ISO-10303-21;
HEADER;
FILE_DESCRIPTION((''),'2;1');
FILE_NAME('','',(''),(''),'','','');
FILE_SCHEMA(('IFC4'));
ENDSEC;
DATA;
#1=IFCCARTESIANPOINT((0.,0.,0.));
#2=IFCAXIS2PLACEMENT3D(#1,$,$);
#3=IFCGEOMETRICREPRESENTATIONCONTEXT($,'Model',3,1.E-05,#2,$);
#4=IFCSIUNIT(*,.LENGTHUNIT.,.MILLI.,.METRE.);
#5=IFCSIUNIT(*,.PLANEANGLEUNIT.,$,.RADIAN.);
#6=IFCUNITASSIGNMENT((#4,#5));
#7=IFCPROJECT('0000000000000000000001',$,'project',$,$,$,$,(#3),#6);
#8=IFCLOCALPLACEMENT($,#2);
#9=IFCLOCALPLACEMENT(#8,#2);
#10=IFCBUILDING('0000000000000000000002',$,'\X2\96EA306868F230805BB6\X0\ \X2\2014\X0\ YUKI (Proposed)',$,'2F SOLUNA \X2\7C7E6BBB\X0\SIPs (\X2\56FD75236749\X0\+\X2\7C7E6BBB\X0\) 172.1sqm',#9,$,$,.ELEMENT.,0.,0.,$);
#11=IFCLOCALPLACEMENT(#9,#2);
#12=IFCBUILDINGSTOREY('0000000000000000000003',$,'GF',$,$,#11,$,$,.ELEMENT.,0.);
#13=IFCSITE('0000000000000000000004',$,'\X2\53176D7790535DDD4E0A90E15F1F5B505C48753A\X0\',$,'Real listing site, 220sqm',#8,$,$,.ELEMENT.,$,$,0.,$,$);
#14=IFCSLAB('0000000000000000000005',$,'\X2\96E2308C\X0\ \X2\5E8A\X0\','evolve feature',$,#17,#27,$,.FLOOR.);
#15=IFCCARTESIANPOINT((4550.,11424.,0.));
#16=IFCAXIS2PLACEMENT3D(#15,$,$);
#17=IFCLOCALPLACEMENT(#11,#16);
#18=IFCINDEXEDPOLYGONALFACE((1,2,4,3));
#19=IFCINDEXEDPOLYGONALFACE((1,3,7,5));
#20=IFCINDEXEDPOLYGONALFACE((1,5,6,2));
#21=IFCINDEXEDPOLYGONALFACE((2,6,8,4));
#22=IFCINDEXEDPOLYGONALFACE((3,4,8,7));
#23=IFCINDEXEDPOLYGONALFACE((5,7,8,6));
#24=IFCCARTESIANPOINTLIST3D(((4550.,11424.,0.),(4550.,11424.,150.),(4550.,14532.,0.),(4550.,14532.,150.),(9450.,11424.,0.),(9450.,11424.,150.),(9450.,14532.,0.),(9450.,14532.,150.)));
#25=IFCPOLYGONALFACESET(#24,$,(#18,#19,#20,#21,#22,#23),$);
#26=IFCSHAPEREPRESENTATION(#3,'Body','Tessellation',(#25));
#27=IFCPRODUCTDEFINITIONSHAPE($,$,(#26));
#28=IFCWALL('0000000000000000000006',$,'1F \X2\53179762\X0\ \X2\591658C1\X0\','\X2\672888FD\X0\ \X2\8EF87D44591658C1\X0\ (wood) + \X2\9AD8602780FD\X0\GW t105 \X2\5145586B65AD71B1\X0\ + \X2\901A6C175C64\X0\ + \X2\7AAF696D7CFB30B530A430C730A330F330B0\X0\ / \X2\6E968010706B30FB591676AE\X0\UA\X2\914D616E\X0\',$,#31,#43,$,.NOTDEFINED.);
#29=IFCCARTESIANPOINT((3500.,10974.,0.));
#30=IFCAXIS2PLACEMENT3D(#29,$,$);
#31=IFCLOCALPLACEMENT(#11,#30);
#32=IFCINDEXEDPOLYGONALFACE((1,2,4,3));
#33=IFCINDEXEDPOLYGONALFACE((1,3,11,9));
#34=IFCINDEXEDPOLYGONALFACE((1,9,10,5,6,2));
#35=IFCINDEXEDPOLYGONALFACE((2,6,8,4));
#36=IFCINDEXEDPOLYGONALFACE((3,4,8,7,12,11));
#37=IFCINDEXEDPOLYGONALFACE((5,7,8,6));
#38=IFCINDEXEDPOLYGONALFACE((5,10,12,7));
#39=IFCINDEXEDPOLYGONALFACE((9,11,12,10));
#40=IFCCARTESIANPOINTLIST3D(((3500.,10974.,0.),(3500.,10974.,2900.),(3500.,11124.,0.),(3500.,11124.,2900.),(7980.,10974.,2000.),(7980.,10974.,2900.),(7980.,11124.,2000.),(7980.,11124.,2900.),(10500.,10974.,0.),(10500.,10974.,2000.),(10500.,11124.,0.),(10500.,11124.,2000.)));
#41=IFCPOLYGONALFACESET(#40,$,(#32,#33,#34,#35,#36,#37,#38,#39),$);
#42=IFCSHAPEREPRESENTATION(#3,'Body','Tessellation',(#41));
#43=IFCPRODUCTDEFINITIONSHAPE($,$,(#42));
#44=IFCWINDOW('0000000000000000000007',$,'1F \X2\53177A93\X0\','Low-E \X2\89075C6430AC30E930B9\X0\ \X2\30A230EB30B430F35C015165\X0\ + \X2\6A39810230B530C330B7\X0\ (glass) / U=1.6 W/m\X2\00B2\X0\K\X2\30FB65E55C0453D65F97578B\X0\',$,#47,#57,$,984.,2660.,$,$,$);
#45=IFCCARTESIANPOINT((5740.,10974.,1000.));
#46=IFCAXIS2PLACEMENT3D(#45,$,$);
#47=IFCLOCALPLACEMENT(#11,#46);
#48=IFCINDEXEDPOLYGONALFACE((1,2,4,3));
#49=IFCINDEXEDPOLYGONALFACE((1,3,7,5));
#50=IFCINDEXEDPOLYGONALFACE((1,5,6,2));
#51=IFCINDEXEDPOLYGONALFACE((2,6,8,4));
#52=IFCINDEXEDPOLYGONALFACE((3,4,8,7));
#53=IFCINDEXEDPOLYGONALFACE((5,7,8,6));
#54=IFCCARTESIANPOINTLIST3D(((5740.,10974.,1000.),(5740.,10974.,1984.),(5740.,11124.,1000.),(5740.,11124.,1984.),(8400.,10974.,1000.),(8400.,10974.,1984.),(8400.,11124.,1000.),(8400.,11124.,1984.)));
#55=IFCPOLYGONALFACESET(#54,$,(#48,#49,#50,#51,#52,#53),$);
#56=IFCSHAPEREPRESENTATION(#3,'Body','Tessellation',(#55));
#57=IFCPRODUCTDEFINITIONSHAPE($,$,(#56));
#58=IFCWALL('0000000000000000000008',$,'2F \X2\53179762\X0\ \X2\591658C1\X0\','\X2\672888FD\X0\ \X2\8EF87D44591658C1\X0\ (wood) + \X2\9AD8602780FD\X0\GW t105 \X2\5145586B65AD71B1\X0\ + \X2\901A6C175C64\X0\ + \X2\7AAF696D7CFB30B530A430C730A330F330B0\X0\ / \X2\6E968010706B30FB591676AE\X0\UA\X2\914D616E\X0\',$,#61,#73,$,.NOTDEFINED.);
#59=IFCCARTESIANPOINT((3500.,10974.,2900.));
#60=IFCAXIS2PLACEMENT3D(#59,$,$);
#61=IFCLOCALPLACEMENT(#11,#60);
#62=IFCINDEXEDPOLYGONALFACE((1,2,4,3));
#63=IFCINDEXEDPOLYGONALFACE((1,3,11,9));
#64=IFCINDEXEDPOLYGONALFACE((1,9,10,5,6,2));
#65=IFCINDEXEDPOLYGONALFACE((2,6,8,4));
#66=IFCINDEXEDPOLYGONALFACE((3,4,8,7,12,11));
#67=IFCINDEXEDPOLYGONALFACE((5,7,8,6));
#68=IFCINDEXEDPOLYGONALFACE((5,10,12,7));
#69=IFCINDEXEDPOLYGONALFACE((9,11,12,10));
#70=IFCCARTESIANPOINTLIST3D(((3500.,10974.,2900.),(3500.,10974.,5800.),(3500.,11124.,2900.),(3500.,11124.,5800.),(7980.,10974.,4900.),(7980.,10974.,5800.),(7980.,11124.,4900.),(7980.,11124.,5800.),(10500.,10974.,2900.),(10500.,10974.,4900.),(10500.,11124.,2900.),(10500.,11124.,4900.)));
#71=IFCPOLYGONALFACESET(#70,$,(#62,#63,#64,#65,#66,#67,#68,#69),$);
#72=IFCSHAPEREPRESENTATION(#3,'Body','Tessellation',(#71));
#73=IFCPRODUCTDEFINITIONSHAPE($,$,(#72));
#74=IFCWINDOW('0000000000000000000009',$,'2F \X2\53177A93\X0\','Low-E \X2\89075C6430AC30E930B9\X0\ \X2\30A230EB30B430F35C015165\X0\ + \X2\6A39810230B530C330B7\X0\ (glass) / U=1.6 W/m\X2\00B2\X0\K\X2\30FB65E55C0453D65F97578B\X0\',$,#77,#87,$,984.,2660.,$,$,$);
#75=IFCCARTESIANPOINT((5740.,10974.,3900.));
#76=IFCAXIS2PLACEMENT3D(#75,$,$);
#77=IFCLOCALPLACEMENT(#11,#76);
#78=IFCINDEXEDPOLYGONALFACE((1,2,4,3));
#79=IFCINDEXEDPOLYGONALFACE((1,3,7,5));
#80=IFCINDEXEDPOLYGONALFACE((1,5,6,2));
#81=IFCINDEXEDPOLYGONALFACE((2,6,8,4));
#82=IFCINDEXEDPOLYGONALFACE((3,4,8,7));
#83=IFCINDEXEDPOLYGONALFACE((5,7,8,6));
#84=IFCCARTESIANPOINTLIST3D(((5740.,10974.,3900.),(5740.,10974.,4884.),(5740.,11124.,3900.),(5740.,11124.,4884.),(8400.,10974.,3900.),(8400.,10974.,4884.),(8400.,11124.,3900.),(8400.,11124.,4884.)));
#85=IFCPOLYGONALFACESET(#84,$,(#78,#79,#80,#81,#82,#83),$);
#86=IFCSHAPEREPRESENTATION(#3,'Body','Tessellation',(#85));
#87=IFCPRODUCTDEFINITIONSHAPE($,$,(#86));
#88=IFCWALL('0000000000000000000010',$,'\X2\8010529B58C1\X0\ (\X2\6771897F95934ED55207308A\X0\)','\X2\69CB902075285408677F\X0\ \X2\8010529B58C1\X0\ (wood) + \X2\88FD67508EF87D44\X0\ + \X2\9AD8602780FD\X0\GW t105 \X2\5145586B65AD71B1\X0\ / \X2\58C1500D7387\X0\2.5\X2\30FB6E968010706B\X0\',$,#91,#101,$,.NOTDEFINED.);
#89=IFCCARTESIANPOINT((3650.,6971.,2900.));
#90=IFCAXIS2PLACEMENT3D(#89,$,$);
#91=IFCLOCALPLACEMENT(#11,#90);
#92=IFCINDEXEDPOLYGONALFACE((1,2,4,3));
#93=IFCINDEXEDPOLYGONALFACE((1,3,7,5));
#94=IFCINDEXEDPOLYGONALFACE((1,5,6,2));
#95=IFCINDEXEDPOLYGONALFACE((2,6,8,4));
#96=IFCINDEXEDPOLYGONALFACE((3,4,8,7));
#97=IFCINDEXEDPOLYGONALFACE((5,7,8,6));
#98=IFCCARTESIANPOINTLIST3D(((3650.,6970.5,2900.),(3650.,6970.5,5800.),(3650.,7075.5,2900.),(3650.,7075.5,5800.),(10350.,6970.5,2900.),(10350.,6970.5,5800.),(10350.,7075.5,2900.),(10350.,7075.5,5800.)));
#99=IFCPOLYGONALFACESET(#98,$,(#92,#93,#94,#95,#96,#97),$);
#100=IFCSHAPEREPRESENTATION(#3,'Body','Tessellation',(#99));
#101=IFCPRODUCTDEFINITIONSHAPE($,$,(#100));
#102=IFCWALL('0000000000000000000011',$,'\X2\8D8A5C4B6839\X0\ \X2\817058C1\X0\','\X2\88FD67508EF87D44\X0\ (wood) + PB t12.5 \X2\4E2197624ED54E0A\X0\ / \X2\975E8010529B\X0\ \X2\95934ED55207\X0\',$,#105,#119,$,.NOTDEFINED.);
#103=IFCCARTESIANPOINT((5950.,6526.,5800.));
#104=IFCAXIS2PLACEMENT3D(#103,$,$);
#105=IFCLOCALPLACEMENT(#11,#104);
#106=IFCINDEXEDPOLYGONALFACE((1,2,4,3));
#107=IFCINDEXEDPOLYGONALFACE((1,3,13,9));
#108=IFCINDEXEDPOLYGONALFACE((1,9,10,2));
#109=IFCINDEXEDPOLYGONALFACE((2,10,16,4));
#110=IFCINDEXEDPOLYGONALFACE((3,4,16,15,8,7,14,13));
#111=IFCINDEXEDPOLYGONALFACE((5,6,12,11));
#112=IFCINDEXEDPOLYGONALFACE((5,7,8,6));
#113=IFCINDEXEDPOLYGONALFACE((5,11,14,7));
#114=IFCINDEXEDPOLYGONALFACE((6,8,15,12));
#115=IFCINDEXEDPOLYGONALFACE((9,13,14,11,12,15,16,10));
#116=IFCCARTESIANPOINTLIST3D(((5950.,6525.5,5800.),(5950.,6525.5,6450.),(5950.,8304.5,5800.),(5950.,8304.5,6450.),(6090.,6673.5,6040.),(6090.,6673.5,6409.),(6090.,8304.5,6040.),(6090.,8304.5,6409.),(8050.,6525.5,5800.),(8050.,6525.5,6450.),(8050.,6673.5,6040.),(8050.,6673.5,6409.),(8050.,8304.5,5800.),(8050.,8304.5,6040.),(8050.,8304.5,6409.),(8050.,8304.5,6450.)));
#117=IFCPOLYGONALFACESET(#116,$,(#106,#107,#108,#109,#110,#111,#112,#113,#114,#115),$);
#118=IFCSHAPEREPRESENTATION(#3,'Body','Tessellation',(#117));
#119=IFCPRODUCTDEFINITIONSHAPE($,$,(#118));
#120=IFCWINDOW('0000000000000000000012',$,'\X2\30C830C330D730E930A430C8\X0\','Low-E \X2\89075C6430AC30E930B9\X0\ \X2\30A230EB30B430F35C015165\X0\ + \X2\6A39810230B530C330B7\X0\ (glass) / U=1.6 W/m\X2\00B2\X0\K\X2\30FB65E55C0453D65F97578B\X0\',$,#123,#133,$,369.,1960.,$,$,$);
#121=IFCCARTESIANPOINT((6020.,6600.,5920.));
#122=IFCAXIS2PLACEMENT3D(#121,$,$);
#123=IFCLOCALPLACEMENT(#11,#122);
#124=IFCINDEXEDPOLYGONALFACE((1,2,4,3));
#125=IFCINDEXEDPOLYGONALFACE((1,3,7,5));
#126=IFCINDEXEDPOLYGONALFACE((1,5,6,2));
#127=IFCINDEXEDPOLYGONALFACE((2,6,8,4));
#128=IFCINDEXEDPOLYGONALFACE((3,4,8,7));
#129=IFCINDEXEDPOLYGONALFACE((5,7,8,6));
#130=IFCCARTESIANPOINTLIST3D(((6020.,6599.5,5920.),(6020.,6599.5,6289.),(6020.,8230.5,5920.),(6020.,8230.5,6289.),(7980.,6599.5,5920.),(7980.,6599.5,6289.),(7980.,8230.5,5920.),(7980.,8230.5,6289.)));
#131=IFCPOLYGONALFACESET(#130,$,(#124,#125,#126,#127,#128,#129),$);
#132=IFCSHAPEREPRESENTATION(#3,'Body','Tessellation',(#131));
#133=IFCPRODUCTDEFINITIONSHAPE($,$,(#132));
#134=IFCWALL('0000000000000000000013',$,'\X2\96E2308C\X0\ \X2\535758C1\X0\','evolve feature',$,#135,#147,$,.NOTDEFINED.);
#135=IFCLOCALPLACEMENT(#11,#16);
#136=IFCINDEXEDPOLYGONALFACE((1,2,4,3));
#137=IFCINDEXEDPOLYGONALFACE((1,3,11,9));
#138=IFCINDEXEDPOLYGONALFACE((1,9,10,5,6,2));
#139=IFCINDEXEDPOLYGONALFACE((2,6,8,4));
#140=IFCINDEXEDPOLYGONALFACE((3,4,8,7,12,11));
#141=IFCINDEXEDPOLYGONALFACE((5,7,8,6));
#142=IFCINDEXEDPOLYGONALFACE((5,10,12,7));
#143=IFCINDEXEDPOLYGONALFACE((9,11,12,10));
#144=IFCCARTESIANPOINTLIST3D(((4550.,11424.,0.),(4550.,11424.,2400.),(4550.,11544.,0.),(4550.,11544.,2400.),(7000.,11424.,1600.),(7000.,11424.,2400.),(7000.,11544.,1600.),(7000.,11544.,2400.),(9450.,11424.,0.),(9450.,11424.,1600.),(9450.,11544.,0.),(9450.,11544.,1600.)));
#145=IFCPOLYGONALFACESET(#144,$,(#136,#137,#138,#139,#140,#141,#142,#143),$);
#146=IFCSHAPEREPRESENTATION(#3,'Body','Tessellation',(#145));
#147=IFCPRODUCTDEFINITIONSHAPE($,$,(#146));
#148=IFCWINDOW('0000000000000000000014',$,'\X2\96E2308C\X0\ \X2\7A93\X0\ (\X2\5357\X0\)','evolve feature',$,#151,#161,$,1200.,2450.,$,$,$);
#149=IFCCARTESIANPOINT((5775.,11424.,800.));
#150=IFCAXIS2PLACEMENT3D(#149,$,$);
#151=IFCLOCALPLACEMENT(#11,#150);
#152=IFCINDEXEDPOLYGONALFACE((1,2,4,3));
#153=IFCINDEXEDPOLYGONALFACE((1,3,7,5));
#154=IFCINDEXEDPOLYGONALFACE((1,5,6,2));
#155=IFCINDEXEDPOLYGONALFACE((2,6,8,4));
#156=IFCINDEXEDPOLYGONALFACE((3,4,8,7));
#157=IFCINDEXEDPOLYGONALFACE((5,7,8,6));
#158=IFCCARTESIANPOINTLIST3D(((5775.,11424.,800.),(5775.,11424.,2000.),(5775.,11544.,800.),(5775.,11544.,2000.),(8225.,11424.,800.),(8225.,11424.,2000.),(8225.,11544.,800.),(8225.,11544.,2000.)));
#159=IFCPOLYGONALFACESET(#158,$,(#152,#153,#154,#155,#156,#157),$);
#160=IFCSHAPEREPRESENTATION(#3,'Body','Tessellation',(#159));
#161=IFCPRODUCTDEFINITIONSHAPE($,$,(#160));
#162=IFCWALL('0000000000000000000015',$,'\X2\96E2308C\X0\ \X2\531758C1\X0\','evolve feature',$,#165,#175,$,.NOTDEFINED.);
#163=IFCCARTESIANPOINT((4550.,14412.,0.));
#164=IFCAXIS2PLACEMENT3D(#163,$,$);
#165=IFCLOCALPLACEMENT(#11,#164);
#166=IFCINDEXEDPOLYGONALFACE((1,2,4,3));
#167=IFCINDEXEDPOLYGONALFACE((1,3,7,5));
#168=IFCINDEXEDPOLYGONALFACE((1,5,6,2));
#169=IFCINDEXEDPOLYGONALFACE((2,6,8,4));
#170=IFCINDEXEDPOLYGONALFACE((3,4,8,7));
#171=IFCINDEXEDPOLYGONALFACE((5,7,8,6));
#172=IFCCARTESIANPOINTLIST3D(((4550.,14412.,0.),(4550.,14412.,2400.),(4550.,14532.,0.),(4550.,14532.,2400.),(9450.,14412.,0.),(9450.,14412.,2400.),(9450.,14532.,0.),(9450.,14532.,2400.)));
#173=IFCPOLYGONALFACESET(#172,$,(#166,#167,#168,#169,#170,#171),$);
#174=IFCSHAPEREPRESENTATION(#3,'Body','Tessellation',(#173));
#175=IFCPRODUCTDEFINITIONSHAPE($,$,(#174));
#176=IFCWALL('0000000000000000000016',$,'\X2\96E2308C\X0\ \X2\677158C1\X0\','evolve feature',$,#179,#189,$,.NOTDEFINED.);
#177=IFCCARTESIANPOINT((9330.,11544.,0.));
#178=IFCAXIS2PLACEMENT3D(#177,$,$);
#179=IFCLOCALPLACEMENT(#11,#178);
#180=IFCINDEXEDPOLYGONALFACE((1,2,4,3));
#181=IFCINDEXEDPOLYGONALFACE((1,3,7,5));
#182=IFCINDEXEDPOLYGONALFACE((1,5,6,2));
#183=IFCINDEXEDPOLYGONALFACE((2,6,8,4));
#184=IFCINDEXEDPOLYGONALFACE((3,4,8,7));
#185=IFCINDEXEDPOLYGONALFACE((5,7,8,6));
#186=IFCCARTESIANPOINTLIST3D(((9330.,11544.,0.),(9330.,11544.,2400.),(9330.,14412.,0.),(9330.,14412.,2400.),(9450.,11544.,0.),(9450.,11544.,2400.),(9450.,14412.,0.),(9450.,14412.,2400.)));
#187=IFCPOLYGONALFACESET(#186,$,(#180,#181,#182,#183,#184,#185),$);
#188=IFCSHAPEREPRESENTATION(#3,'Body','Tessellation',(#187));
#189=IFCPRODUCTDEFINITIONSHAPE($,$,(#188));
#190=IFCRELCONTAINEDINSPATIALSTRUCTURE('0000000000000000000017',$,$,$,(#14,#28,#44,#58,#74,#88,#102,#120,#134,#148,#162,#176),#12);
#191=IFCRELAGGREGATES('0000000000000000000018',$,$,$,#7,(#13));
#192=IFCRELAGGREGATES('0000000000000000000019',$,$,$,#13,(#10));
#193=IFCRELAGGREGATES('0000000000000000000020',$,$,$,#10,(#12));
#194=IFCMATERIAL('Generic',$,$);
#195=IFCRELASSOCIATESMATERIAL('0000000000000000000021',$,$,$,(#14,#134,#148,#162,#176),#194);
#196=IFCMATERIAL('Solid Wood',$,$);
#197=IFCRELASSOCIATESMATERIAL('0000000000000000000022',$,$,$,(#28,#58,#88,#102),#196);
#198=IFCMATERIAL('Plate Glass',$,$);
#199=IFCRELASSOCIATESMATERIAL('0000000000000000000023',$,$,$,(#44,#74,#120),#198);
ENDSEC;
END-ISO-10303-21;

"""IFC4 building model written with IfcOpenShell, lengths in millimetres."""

from ifc_helpers import new_model, si_unit, frame, frame_2d, origin, place, context, project, spatial, rectangle, extrude, material, element, fill, save


model = new_model("IFC4")

# Units and contexts
model_context = context("Model", 3, precision=1e-05, world=origin())
ifc_project = project(units=[si_unit("LENGTHUNIT", "METRE", prefix="MILLI"), si_unit("PLANEANGLEUNIT", "RADIAN")], contexts=[model_context])

# Site, building, storey
site_placement = place(None, origin())
site = spatial("IfcSite", under=ifc_project, at=site_placement, Name="北海道川上郡弟子屈町", ObjectType="Real listing site, 220sqm", CompositionType="ELEMENT", RefElevation=0.0)
building_placement = place(site_placement, origin())
building = spatial("IfcBuilding", under=site, at=building_placement, Name="雪と棲む家 — YUKI (Proposed)", ObjectType="2F SOLUNA 籾殻SIPs (国産杉+籾殻) 172.1sqm", CompositionType="ELEMENT", ElevationOfRefHeight=0.0, ElevationOfTerrain=0.0)
storey_placement = place(building_placement, origin())
storey = spatial("IfcBuildingStorey", under=building, at=storey_placement, Name="GF", CompositionType="ELEMENT", Elevation=0.0)

# Slab
ifc_material_1 = material(Name="Generic")
slab_placement = place(storey_placement, frame((4550.0, 11424.0, 0.0)))
element("IfcSlab", 1, at=slab_placement, inside=storey, material=ifc_material_1, Name="離れ 床", Description="evolve feature", PredefinedType="FLOOR", context=model_context, shape_type="SweptSolid", body=[
    extrude(rectangle(XDim=4900.0, YDim=3108.0, at=frame_2d((2450.0, 1554.0))), frame((4550.0, 11424.0, 0.0)), (0.0, 0.0, 1.0), 150.0),
])

# Wall, opening, window
ifc_material_2 = material(Name="Solid Wood")
wall_1_placement = place(storey_placement, frame((3500.0, 10974.0, 0.0)))
wall_1 = element("IfcWall", 2, at=wall_1_placement, inside=storey, material=ifc_material_2, Name="1F 北面 外壁", Description="木製 軸組外壁 (wood) + 高性能GW t105 充填断熱 + 通気層 + 窯業系サイディング / 準耐火・外皮UA配慮", PredefinedType="NOTDEFINED", context=model_context, shape_type="SweptSolid", body=[
    extrude(rectangle(XDim=7000.0, YDim=150.0, at=frame_2d((3500.0, 75.0))), frame((3500.0, 10974.0, 0.0)), (0.0, 0.0, 1.0), 2900.0),
])
opening_1_placement = place(storey_placement, frame((5740.0, 10974.0, 1000.0)))
opening_1 = element("IfcOpeningElement", 3, at=opening_1_placement, cuts=wall_1, PredefinedType="NOTDEFINED", context=model_context, shape_type="SweptSolid", body=[
    extrude(rectangle(XDim=2660.0, YDim=150.0, at=frame_2d((1330.0, 75.0))), frame((5740.0, 10974.0, 1000.0)), (0.0, 0.0, 1.0), 984.0),
])
ifc_material_3 = material(Name="Plate Glass")
window_1_placement = place(storey_placement, frame((5740.0, 10974.0, 1000.0)))
window_1 = element("IfcWindow", 4, at=window_1_placement, inside=storey, material=ifc_material_3, Name="1F 北窓", Description="Low-E 複層ガラス アルゴン封入 + 樹脂サッシ (glass) / U=1.6 W/m²K・日射取得型", OverallHeight=984.0, OverallWidth=2660.0, context=model_context, shape_type="SweptSolid", body=[
    extrude(rectangle(XDim=2660.0, YDim=150.0, at=frame_2d((1330.0, 75.0))), frame((5740.0, 10974.0, 1000.0)), (0.0, 0.0, 1.0), 984.0),
])
fill(opening_1, window_1)

# Wall, opening, window
wall_2_placement = place(storey_placement, frame((3500.0, 10974.0, 2900.0)))
wall_2 = element("IfcWall", 5, at=wall_2_placement, inside=storey, material=ifc_material_2, Name="2F 北面 外壁", Description="木製 軸組外壁 (wood) + 高性能GW t105 充填断熱 + 通気層 + 窯業系サイディング / 準耐火・外皮UA配慮", PredefinedType="NOTDEFINED", context=model_context, shape_type="SweptSolid", body=[
    extrude(rectangle(XDim=7000.0, YDim=150.0, at=frame_2d((3500.0, 75.0))), frame((3500.0, 10974.0, 2900.0)), (0.0, 0.0, 1.0), 2900.0),
])
opening_2_placement = place(storey_placement, frame((5740.0, 10974.0, 3900.0)))
opening_2 = element("IfcOpeningElement", 6, at=opening_2_placement, cuts=wall_2, PredefinedType="NOTDEFINED", context=model_context, shape_type="SweptSolid", body=[
    extrude(rectangle(XDim=2660.0, YDim=150.0, at=frame_2d((1330.0, 75.0))), frame((5740.0, 10974.0, 3900.0)), (0.0, 0.0, 1.0), 984.0),
])
window_2_placement = place(storey_placement, frame((5740.0, 10974.0, 3900.0)))
window_2 = element("IfcWindow", 7, at=window_2_placement, inside=storey, material=ifc_material_3, Name="2F 北窓", Description="Low-E 複層ガラス アルゴン封入 + 樹脂サッシ (glass) / U=1.6 W/m²K・日射取得型", OverallHeight=984.0, OverallWidth=2660.0, context=model_context, shape_type="SweptSolid", body=[
    extrude(rectangle(XDim=2660.0, YDim=150.0, at=frame_2d((1330.0, 75.0))), frame((5740.0, 10974.0, 3900.0)), (0.0, 0.0, 1.0), 984.0),
])
fill(opening_2, window_2)

# Wall
wall_3_placement = place(storey_placement, frame((3650.0, 6971.0, 2900.0)))
element("IfcWall", 8, at=wall_3_placement, inside=storey, material=ifc_material_2, Name="耐力壁 (東西間仕切り)", Description="構造用合板 耐力壁 (wood) + 製材軸組 + 高性能GW t105 充填断熱 / 壁倍率2.5・準耐火", PredefinedType="NOTDEFINED", context=model_context, shape_type="SweptSolid", body=[
    extrude(rectangle(XDim=6700.0, YDim=105.0, at=frame_2d((3350.0, 52.0))), frame((3650.0, 6971.0, 2900.0)), (0.0, 0.0, 1.0), 2900.0),
])

# Walls, openings, windows
wall_4_placement = place(storey_placement, frame((5950.0, 6526.0, 5800.0)))
wall_4 = element("IfcWall", 9, at=wall_4_placement, inside=storey, material=ifc_material_2, Name="越屋根 腰壁", Description="製材軸組 (wood) + PB t12.5 両面仕上 / 非耐力 間仕切", PredefinedType="NOTDEFINED", context=model_context, shape_type="SweptSolid", body=[
    extrude(rectangle(XDim=2100.0, YDim=1779.0, at=frame_2d((1050.0, 889.0))), frame((5950.0, 6526.0, 5800.0)), (0.0, 0.0, 1.0), 650.0),
])
opening_3_placement = place(storey_placement, frame((6020.0, 6600.0, 5920.0)))
opening_3 = element("IfcOpeningElement", 10, at=opening_3_placement, cuts=wall_4, PredefinedType="NOTDEFINED", context=model_context, shape_type="SweptSolid", body=[
    extrude(rectangle(XDim=1960.0, YDim=1631.0, at=frame_2d((980.0, 815.0))), frame((6020.0, 6600.0, 5920.0)), (0.0, 0.0, 1.0), 369.0),
])
window_3_placement = place(storey_placement, frame((6020.0, 6600.0, 5920.0)))
window_3 = element("IfcWindow", 11, at=window_3_placement, inside=storey, material=ifc_material_3, Name="トップライト", Description="Low-E 複層ガラス アルゴン封入 + 樹脂サッシ (glass) / U=1.6 W/m²K・日射取得型", OverallHeight=369.0, OverallWidth=1960.0, context=model_context, shape_type="SweptSolid", body=[
    extrude(rectangle(XDim=1960.0, YDim=1631.0, at=frame_2d((980.0, 815.0))), frame((6020.0, 6600.0, 5920.0)), (0.0, 0.0, 1.0), 369.0),
])
fill(opening_3, window_3)
wall_5_placement = place(storey_placement, frame((4550.0, 11424.0, 0.0)))
wall_5 = element("IfcWall", 12, at=wall_5_placement, inside=storey, material=ifc_material_1, Name="離れ 南壁", Description="evolve feature", PredefinedType="NOTDEFINED", context=model_context, shape_type="SweptSolid", body=[
    extrude(rectangle(XDim=4900.0, YDim=120.0, at=frame_2d((2450.0, 60.0))), frame((4550.0, 11424.0, 0.0)), (0.0, 0.0, 1.0), 2400.0),
])
opening_4_placement = place(storey_placement, frame((5775.0, 11424.0, 800.0)))
opening_4 = element("IfcOpeningElement", 13, at=opening_4_placement, cuts=wall_5, PredefinedType="NOTDEFINED", context=model_context, shape_type="SweptSolid", body=[
    extrude(rectangle(XDim=2450.0, YDim=120.0, at=frame_2d((1225.0, 60.0))), frame((5775.0, 11424.0, 800.0)), (0.0, 0.0, 1.0), 1200.0),
])
window_4_placement = place(storey_placement, frame((5775.0, 11424.0, 800.0)))
window_4 = element("IfcWindow", 14, at=window_4_placement, inside=storey, material=ifc_material_1, Name="離れ 窓 (南)", Description="evolve feature", OverallHeight=1200.0, OverallWidth=2450.0, context=model_context, shape_type="SweptSolid", body=[
    extrude(rectangle(XDim=2450.0, YDim=120.0, at=frame_2d((1225.0, 60.0))), frame((5775.0, 11424.0, 800.0)), (0.0, 0.0, 1.0), 1200.0),
])
fill(opening_4, window_4)

# Walls
wall_6_placement = place(storey_placement, frame((4550.0, 14412.0, 0.0)))
element("IfcWall", 15, at=wall_6_placement, inside=storey, material=ifc_material_1, Name="離れ 北壁", Description="evolve feature", PredefinedType="NOTDEFINED", context=model_context, shape_type="SweptSolid", body=[
    extrude(rectangle(XDim=4900.0, YDim=120.0, at=frame_2d((2450.0, 60.0))), frame((4550.0, 14412.0, 0.0)), (0.0, 0.0, 1.0), 2400.0),
])
wall_7_placement = place(storey_placement, frame((9330.0, 11544.0, 0.0)))
element("IfcWall", 16, at=wall_7_placement, inside=storey, material=ifc_material_1, Name="離れ 東壁", Description="evolve feature", PredefinedType="NOTDEFINED", context=model_context, shape_type="SweptSolid", body=[
    extrude(rectangle(XDim=120.0, YDim=2868.0, at=frame_2d((60.0, 1434.0))), frame((9330.0, 11544.0, 0.0)), (0.0, 0.0, 1.0), 2400.0),
])

save(model, "model.ifc")
